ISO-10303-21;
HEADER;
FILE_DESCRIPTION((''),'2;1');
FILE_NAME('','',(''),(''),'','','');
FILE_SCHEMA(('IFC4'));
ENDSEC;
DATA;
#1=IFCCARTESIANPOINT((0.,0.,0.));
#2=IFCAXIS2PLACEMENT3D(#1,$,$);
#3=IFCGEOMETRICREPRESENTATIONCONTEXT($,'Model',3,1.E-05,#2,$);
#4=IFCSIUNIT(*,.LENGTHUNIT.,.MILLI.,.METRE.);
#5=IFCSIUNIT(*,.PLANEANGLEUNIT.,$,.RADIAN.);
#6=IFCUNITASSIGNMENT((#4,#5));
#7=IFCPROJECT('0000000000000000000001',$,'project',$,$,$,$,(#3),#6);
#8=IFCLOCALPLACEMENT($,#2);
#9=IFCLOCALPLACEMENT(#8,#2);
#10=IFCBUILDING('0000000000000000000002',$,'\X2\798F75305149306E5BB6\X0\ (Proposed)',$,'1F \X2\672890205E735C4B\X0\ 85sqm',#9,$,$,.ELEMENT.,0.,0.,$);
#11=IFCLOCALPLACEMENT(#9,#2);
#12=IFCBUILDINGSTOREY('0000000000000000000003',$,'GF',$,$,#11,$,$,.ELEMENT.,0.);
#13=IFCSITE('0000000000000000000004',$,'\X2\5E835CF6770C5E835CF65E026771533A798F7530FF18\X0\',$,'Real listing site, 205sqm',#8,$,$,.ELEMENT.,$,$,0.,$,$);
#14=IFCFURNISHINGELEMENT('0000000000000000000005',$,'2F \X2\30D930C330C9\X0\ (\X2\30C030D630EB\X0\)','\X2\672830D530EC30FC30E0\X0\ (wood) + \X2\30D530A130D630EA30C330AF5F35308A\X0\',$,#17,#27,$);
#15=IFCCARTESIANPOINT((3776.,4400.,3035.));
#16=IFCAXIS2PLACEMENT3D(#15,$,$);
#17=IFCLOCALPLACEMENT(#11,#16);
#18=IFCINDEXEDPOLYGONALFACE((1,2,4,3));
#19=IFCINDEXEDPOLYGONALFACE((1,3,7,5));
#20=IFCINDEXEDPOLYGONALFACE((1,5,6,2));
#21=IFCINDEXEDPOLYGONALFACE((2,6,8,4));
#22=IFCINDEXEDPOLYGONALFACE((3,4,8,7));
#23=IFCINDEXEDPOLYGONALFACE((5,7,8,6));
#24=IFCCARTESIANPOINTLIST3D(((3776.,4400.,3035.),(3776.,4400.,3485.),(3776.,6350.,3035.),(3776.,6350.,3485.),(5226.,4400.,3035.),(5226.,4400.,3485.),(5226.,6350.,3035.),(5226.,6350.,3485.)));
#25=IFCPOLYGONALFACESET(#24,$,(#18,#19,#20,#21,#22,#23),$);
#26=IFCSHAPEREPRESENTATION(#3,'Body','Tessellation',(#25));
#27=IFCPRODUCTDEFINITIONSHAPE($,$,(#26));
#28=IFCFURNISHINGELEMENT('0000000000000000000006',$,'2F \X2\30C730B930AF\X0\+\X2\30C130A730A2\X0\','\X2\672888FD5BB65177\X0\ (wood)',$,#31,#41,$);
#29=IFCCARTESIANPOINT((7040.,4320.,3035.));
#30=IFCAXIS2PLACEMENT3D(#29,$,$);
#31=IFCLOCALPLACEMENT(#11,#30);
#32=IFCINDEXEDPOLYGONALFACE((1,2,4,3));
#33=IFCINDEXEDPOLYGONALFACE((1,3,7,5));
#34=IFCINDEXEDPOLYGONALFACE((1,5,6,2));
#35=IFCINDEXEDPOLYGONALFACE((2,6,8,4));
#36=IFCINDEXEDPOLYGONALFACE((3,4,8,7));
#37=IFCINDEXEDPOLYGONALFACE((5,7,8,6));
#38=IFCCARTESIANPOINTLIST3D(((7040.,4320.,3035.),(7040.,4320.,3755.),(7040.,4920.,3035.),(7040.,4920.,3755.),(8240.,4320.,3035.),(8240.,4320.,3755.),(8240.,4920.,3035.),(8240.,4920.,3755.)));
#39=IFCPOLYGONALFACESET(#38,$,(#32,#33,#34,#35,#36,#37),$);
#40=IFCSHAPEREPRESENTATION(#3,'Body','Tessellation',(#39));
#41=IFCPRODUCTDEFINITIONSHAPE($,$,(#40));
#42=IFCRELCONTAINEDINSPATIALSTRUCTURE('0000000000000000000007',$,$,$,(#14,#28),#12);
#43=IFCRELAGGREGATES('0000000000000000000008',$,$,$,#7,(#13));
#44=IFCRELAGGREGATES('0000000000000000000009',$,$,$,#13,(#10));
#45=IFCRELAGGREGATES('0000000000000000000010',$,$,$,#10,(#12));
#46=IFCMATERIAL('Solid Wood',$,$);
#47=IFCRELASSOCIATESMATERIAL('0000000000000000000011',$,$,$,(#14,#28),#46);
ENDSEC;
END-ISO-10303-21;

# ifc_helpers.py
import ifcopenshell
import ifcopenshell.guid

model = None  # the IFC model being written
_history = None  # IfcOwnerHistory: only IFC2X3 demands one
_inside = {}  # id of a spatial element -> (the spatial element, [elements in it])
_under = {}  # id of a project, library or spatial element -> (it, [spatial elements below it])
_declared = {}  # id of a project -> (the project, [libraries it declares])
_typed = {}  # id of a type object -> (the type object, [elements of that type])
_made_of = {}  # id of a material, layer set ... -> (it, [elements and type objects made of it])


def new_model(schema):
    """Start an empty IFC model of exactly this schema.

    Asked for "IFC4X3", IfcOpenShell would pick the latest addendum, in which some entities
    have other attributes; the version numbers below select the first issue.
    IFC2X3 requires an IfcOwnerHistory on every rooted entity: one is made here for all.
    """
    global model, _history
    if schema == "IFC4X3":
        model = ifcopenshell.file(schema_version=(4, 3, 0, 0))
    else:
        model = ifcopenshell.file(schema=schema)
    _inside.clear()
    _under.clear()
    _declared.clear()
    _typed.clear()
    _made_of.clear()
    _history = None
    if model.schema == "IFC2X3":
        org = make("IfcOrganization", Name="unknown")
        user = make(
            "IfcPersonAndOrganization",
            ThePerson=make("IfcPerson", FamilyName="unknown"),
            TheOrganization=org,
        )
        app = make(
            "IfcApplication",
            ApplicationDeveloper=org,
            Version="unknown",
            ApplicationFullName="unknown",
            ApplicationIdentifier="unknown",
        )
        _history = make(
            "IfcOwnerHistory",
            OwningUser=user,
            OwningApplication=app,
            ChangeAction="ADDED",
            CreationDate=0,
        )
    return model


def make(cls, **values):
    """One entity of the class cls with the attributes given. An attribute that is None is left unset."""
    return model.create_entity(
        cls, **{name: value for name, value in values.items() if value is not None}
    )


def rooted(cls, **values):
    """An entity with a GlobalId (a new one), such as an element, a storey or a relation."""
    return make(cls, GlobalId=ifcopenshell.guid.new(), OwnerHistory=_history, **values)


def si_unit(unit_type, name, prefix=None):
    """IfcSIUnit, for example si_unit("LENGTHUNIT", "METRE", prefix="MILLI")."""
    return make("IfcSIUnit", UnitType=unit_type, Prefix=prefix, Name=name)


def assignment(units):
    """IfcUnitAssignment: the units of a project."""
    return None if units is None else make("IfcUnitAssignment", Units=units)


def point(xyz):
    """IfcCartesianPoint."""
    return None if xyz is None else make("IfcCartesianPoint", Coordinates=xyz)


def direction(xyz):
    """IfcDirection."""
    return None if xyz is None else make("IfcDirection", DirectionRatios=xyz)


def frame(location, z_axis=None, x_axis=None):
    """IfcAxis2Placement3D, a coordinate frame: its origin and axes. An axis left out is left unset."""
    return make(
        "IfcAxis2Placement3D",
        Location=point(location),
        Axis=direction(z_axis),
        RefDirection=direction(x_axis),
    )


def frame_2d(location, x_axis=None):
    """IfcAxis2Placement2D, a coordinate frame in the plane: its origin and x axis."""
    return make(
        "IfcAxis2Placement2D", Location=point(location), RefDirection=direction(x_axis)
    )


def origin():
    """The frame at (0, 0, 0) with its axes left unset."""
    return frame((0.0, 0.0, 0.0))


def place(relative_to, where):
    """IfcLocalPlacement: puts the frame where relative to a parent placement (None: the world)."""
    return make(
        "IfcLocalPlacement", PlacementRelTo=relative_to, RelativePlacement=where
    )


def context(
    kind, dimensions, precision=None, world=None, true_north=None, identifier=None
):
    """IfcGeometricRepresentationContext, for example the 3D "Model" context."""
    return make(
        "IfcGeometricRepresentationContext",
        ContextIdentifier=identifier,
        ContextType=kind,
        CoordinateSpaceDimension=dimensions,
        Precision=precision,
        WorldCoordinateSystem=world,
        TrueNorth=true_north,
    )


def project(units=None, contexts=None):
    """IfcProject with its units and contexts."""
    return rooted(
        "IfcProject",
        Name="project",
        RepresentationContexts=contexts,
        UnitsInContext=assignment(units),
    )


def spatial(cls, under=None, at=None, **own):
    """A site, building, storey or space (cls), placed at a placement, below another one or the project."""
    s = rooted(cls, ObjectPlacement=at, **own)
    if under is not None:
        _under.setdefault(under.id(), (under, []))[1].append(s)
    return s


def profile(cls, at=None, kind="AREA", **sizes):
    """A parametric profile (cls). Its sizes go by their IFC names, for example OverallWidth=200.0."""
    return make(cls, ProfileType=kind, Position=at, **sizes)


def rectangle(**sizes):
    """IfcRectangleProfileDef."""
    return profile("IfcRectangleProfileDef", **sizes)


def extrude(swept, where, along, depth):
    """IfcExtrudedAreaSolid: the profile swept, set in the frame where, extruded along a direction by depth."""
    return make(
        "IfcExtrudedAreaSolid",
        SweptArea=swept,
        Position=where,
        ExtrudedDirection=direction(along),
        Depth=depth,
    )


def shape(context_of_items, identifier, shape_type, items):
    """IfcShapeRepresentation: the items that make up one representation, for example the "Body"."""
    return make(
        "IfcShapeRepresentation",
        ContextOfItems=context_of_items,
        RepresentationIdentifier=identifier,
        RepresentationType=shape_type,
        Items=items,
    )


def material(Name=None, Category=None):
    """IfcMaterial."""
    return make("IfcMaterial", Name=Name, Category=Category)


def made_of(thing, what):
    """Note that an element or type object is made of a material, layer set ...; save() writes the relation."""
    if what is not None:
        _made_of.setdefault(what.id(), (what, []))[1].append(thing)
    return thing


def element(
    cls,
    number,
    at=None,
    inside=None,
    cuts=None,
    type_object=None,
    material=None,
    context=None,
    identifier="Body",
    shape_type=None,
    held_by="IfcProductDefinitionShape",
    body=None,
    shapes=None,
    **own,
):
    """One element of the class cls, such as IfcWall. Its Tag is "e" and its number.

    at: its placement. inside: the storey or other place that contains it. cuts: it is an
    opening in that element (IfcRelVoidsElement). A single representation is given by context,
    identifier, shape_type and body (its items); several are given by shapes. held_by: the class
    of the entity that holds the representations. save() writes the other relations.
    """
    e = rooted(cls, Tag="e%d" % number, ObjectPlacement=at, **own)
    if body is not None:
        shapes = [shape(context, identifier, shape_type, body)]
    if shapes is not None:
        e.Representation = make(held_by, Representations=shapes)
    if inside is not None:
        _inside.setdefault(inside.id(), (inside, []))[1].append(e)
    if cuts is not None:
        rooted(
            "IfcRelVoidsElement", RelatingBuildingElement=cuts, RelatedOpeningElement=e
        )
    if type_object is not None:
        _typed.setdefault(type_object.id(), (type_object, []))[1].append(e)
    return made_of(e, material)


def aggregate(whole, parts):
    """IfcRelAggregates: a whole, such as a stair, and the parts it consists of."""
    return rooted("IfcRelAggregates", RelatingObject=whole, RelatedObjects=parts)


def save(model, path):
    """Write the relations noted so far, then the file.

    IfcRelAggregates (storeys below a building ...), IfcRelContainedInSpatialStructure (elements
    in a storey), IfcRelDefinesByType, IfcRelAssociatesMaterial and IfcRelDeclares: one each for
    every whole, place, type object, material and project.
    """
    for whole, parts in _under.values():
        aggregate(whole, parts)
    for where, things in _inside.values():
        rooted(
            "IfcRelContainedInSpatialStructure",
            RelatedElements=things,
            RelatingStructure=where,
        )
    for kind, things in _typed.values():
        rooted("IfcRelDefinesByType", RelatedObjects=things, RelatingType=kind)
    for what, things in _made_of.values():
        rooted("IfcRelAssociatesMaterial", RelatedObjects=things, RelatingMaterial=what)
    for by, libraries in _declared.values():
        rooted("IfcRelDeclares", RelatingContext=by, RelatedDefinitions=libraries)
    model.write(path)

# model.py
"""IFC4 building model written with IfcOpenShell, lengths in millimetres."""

from ifc_helpers import new_model, si_unit, frame, frame_2d, origin, place, context, project, spatial, rectangle, extrude, material, element, save


model = new_model("IFC4")

# Units and contexts
model_context = context("Model", 3, precision=1e-05, world=origin())
ifc_project = project(units=[si_unit("LENGTHUNIT", "METRE", prefix="MILLI"), si_unit("PLANEANGLEUNIT", "RADIAN")], contexts=[model_context])

# Site, building, storey
site_placement = place(None, origin())
site = spatial("IfcSite", under=ifc_project, at=site_placement, Name="広島県広島市東区福田８", ObjectType="Real listing site, 205sqm", CompositionType="ELEMENT", RefElevation=0.0)
building_placement = place(site_placement, origin())
building = spatial("IfcBuilding", under=site, at=building_placement, Name="福田光の家 (Proposed)", ObjectType="1F 木造平屋 85sqm", CompositionType="ELEMENT", ElevationOfRefHeight=0.0, ElevationOfTerrain=0.0)
storey_placement = place(building_placement, origin())
storey = spatial("IfcBuildingStorey", under=building, at=storey_placement, Name="GF", CompositionType="ELEMENT", Elevation=0.0)

# Shared definitions
ifc_material_1 = material(Name="Solid Wood")

# Furnishing elements
furnishing_1_placement = place(storey_placement, frame((3776.0, 4400.0, 3035.0)))
element("IfcFurnishingElement", 1, at=furnishing_1_placement, inside=storey, material=ifc_material_1, Name="2F ベッド (ダブル)", Description="木フレーム (wood) + ファブリック張り", context=model_context, shape_type="SweptSolid", body=[
    extrude(rectangle(XDim=1450.0, YDim=1950.0, at=frame_2d((725.0, 975.0))), frame((3776.0, 4400.0, 3035.0)), (0.0, 0.0, 1.0), 450.0),
])
furnishing_2_placement = place(storey_placement, frame((7040.0, 4320.0, 3035.0)))
element("IfcFurnishingElement", 2, at=furnishing_2_placement, inside=storey, material=ifc_material_1, Name="2F デスク+チェア", Description="木製家具 (wood)", context=model_context, shape_type="SweptSolid", body=[
    extrude(rectangle(XDim=1200.0, YDim=600.0, at=frame_2d((600.0, 300.0))), frame((7040.0, 4320.0, 3035.0)), (0.0, 0.0, 1.0), 720.0),
])

save(model, "model.ifc")
